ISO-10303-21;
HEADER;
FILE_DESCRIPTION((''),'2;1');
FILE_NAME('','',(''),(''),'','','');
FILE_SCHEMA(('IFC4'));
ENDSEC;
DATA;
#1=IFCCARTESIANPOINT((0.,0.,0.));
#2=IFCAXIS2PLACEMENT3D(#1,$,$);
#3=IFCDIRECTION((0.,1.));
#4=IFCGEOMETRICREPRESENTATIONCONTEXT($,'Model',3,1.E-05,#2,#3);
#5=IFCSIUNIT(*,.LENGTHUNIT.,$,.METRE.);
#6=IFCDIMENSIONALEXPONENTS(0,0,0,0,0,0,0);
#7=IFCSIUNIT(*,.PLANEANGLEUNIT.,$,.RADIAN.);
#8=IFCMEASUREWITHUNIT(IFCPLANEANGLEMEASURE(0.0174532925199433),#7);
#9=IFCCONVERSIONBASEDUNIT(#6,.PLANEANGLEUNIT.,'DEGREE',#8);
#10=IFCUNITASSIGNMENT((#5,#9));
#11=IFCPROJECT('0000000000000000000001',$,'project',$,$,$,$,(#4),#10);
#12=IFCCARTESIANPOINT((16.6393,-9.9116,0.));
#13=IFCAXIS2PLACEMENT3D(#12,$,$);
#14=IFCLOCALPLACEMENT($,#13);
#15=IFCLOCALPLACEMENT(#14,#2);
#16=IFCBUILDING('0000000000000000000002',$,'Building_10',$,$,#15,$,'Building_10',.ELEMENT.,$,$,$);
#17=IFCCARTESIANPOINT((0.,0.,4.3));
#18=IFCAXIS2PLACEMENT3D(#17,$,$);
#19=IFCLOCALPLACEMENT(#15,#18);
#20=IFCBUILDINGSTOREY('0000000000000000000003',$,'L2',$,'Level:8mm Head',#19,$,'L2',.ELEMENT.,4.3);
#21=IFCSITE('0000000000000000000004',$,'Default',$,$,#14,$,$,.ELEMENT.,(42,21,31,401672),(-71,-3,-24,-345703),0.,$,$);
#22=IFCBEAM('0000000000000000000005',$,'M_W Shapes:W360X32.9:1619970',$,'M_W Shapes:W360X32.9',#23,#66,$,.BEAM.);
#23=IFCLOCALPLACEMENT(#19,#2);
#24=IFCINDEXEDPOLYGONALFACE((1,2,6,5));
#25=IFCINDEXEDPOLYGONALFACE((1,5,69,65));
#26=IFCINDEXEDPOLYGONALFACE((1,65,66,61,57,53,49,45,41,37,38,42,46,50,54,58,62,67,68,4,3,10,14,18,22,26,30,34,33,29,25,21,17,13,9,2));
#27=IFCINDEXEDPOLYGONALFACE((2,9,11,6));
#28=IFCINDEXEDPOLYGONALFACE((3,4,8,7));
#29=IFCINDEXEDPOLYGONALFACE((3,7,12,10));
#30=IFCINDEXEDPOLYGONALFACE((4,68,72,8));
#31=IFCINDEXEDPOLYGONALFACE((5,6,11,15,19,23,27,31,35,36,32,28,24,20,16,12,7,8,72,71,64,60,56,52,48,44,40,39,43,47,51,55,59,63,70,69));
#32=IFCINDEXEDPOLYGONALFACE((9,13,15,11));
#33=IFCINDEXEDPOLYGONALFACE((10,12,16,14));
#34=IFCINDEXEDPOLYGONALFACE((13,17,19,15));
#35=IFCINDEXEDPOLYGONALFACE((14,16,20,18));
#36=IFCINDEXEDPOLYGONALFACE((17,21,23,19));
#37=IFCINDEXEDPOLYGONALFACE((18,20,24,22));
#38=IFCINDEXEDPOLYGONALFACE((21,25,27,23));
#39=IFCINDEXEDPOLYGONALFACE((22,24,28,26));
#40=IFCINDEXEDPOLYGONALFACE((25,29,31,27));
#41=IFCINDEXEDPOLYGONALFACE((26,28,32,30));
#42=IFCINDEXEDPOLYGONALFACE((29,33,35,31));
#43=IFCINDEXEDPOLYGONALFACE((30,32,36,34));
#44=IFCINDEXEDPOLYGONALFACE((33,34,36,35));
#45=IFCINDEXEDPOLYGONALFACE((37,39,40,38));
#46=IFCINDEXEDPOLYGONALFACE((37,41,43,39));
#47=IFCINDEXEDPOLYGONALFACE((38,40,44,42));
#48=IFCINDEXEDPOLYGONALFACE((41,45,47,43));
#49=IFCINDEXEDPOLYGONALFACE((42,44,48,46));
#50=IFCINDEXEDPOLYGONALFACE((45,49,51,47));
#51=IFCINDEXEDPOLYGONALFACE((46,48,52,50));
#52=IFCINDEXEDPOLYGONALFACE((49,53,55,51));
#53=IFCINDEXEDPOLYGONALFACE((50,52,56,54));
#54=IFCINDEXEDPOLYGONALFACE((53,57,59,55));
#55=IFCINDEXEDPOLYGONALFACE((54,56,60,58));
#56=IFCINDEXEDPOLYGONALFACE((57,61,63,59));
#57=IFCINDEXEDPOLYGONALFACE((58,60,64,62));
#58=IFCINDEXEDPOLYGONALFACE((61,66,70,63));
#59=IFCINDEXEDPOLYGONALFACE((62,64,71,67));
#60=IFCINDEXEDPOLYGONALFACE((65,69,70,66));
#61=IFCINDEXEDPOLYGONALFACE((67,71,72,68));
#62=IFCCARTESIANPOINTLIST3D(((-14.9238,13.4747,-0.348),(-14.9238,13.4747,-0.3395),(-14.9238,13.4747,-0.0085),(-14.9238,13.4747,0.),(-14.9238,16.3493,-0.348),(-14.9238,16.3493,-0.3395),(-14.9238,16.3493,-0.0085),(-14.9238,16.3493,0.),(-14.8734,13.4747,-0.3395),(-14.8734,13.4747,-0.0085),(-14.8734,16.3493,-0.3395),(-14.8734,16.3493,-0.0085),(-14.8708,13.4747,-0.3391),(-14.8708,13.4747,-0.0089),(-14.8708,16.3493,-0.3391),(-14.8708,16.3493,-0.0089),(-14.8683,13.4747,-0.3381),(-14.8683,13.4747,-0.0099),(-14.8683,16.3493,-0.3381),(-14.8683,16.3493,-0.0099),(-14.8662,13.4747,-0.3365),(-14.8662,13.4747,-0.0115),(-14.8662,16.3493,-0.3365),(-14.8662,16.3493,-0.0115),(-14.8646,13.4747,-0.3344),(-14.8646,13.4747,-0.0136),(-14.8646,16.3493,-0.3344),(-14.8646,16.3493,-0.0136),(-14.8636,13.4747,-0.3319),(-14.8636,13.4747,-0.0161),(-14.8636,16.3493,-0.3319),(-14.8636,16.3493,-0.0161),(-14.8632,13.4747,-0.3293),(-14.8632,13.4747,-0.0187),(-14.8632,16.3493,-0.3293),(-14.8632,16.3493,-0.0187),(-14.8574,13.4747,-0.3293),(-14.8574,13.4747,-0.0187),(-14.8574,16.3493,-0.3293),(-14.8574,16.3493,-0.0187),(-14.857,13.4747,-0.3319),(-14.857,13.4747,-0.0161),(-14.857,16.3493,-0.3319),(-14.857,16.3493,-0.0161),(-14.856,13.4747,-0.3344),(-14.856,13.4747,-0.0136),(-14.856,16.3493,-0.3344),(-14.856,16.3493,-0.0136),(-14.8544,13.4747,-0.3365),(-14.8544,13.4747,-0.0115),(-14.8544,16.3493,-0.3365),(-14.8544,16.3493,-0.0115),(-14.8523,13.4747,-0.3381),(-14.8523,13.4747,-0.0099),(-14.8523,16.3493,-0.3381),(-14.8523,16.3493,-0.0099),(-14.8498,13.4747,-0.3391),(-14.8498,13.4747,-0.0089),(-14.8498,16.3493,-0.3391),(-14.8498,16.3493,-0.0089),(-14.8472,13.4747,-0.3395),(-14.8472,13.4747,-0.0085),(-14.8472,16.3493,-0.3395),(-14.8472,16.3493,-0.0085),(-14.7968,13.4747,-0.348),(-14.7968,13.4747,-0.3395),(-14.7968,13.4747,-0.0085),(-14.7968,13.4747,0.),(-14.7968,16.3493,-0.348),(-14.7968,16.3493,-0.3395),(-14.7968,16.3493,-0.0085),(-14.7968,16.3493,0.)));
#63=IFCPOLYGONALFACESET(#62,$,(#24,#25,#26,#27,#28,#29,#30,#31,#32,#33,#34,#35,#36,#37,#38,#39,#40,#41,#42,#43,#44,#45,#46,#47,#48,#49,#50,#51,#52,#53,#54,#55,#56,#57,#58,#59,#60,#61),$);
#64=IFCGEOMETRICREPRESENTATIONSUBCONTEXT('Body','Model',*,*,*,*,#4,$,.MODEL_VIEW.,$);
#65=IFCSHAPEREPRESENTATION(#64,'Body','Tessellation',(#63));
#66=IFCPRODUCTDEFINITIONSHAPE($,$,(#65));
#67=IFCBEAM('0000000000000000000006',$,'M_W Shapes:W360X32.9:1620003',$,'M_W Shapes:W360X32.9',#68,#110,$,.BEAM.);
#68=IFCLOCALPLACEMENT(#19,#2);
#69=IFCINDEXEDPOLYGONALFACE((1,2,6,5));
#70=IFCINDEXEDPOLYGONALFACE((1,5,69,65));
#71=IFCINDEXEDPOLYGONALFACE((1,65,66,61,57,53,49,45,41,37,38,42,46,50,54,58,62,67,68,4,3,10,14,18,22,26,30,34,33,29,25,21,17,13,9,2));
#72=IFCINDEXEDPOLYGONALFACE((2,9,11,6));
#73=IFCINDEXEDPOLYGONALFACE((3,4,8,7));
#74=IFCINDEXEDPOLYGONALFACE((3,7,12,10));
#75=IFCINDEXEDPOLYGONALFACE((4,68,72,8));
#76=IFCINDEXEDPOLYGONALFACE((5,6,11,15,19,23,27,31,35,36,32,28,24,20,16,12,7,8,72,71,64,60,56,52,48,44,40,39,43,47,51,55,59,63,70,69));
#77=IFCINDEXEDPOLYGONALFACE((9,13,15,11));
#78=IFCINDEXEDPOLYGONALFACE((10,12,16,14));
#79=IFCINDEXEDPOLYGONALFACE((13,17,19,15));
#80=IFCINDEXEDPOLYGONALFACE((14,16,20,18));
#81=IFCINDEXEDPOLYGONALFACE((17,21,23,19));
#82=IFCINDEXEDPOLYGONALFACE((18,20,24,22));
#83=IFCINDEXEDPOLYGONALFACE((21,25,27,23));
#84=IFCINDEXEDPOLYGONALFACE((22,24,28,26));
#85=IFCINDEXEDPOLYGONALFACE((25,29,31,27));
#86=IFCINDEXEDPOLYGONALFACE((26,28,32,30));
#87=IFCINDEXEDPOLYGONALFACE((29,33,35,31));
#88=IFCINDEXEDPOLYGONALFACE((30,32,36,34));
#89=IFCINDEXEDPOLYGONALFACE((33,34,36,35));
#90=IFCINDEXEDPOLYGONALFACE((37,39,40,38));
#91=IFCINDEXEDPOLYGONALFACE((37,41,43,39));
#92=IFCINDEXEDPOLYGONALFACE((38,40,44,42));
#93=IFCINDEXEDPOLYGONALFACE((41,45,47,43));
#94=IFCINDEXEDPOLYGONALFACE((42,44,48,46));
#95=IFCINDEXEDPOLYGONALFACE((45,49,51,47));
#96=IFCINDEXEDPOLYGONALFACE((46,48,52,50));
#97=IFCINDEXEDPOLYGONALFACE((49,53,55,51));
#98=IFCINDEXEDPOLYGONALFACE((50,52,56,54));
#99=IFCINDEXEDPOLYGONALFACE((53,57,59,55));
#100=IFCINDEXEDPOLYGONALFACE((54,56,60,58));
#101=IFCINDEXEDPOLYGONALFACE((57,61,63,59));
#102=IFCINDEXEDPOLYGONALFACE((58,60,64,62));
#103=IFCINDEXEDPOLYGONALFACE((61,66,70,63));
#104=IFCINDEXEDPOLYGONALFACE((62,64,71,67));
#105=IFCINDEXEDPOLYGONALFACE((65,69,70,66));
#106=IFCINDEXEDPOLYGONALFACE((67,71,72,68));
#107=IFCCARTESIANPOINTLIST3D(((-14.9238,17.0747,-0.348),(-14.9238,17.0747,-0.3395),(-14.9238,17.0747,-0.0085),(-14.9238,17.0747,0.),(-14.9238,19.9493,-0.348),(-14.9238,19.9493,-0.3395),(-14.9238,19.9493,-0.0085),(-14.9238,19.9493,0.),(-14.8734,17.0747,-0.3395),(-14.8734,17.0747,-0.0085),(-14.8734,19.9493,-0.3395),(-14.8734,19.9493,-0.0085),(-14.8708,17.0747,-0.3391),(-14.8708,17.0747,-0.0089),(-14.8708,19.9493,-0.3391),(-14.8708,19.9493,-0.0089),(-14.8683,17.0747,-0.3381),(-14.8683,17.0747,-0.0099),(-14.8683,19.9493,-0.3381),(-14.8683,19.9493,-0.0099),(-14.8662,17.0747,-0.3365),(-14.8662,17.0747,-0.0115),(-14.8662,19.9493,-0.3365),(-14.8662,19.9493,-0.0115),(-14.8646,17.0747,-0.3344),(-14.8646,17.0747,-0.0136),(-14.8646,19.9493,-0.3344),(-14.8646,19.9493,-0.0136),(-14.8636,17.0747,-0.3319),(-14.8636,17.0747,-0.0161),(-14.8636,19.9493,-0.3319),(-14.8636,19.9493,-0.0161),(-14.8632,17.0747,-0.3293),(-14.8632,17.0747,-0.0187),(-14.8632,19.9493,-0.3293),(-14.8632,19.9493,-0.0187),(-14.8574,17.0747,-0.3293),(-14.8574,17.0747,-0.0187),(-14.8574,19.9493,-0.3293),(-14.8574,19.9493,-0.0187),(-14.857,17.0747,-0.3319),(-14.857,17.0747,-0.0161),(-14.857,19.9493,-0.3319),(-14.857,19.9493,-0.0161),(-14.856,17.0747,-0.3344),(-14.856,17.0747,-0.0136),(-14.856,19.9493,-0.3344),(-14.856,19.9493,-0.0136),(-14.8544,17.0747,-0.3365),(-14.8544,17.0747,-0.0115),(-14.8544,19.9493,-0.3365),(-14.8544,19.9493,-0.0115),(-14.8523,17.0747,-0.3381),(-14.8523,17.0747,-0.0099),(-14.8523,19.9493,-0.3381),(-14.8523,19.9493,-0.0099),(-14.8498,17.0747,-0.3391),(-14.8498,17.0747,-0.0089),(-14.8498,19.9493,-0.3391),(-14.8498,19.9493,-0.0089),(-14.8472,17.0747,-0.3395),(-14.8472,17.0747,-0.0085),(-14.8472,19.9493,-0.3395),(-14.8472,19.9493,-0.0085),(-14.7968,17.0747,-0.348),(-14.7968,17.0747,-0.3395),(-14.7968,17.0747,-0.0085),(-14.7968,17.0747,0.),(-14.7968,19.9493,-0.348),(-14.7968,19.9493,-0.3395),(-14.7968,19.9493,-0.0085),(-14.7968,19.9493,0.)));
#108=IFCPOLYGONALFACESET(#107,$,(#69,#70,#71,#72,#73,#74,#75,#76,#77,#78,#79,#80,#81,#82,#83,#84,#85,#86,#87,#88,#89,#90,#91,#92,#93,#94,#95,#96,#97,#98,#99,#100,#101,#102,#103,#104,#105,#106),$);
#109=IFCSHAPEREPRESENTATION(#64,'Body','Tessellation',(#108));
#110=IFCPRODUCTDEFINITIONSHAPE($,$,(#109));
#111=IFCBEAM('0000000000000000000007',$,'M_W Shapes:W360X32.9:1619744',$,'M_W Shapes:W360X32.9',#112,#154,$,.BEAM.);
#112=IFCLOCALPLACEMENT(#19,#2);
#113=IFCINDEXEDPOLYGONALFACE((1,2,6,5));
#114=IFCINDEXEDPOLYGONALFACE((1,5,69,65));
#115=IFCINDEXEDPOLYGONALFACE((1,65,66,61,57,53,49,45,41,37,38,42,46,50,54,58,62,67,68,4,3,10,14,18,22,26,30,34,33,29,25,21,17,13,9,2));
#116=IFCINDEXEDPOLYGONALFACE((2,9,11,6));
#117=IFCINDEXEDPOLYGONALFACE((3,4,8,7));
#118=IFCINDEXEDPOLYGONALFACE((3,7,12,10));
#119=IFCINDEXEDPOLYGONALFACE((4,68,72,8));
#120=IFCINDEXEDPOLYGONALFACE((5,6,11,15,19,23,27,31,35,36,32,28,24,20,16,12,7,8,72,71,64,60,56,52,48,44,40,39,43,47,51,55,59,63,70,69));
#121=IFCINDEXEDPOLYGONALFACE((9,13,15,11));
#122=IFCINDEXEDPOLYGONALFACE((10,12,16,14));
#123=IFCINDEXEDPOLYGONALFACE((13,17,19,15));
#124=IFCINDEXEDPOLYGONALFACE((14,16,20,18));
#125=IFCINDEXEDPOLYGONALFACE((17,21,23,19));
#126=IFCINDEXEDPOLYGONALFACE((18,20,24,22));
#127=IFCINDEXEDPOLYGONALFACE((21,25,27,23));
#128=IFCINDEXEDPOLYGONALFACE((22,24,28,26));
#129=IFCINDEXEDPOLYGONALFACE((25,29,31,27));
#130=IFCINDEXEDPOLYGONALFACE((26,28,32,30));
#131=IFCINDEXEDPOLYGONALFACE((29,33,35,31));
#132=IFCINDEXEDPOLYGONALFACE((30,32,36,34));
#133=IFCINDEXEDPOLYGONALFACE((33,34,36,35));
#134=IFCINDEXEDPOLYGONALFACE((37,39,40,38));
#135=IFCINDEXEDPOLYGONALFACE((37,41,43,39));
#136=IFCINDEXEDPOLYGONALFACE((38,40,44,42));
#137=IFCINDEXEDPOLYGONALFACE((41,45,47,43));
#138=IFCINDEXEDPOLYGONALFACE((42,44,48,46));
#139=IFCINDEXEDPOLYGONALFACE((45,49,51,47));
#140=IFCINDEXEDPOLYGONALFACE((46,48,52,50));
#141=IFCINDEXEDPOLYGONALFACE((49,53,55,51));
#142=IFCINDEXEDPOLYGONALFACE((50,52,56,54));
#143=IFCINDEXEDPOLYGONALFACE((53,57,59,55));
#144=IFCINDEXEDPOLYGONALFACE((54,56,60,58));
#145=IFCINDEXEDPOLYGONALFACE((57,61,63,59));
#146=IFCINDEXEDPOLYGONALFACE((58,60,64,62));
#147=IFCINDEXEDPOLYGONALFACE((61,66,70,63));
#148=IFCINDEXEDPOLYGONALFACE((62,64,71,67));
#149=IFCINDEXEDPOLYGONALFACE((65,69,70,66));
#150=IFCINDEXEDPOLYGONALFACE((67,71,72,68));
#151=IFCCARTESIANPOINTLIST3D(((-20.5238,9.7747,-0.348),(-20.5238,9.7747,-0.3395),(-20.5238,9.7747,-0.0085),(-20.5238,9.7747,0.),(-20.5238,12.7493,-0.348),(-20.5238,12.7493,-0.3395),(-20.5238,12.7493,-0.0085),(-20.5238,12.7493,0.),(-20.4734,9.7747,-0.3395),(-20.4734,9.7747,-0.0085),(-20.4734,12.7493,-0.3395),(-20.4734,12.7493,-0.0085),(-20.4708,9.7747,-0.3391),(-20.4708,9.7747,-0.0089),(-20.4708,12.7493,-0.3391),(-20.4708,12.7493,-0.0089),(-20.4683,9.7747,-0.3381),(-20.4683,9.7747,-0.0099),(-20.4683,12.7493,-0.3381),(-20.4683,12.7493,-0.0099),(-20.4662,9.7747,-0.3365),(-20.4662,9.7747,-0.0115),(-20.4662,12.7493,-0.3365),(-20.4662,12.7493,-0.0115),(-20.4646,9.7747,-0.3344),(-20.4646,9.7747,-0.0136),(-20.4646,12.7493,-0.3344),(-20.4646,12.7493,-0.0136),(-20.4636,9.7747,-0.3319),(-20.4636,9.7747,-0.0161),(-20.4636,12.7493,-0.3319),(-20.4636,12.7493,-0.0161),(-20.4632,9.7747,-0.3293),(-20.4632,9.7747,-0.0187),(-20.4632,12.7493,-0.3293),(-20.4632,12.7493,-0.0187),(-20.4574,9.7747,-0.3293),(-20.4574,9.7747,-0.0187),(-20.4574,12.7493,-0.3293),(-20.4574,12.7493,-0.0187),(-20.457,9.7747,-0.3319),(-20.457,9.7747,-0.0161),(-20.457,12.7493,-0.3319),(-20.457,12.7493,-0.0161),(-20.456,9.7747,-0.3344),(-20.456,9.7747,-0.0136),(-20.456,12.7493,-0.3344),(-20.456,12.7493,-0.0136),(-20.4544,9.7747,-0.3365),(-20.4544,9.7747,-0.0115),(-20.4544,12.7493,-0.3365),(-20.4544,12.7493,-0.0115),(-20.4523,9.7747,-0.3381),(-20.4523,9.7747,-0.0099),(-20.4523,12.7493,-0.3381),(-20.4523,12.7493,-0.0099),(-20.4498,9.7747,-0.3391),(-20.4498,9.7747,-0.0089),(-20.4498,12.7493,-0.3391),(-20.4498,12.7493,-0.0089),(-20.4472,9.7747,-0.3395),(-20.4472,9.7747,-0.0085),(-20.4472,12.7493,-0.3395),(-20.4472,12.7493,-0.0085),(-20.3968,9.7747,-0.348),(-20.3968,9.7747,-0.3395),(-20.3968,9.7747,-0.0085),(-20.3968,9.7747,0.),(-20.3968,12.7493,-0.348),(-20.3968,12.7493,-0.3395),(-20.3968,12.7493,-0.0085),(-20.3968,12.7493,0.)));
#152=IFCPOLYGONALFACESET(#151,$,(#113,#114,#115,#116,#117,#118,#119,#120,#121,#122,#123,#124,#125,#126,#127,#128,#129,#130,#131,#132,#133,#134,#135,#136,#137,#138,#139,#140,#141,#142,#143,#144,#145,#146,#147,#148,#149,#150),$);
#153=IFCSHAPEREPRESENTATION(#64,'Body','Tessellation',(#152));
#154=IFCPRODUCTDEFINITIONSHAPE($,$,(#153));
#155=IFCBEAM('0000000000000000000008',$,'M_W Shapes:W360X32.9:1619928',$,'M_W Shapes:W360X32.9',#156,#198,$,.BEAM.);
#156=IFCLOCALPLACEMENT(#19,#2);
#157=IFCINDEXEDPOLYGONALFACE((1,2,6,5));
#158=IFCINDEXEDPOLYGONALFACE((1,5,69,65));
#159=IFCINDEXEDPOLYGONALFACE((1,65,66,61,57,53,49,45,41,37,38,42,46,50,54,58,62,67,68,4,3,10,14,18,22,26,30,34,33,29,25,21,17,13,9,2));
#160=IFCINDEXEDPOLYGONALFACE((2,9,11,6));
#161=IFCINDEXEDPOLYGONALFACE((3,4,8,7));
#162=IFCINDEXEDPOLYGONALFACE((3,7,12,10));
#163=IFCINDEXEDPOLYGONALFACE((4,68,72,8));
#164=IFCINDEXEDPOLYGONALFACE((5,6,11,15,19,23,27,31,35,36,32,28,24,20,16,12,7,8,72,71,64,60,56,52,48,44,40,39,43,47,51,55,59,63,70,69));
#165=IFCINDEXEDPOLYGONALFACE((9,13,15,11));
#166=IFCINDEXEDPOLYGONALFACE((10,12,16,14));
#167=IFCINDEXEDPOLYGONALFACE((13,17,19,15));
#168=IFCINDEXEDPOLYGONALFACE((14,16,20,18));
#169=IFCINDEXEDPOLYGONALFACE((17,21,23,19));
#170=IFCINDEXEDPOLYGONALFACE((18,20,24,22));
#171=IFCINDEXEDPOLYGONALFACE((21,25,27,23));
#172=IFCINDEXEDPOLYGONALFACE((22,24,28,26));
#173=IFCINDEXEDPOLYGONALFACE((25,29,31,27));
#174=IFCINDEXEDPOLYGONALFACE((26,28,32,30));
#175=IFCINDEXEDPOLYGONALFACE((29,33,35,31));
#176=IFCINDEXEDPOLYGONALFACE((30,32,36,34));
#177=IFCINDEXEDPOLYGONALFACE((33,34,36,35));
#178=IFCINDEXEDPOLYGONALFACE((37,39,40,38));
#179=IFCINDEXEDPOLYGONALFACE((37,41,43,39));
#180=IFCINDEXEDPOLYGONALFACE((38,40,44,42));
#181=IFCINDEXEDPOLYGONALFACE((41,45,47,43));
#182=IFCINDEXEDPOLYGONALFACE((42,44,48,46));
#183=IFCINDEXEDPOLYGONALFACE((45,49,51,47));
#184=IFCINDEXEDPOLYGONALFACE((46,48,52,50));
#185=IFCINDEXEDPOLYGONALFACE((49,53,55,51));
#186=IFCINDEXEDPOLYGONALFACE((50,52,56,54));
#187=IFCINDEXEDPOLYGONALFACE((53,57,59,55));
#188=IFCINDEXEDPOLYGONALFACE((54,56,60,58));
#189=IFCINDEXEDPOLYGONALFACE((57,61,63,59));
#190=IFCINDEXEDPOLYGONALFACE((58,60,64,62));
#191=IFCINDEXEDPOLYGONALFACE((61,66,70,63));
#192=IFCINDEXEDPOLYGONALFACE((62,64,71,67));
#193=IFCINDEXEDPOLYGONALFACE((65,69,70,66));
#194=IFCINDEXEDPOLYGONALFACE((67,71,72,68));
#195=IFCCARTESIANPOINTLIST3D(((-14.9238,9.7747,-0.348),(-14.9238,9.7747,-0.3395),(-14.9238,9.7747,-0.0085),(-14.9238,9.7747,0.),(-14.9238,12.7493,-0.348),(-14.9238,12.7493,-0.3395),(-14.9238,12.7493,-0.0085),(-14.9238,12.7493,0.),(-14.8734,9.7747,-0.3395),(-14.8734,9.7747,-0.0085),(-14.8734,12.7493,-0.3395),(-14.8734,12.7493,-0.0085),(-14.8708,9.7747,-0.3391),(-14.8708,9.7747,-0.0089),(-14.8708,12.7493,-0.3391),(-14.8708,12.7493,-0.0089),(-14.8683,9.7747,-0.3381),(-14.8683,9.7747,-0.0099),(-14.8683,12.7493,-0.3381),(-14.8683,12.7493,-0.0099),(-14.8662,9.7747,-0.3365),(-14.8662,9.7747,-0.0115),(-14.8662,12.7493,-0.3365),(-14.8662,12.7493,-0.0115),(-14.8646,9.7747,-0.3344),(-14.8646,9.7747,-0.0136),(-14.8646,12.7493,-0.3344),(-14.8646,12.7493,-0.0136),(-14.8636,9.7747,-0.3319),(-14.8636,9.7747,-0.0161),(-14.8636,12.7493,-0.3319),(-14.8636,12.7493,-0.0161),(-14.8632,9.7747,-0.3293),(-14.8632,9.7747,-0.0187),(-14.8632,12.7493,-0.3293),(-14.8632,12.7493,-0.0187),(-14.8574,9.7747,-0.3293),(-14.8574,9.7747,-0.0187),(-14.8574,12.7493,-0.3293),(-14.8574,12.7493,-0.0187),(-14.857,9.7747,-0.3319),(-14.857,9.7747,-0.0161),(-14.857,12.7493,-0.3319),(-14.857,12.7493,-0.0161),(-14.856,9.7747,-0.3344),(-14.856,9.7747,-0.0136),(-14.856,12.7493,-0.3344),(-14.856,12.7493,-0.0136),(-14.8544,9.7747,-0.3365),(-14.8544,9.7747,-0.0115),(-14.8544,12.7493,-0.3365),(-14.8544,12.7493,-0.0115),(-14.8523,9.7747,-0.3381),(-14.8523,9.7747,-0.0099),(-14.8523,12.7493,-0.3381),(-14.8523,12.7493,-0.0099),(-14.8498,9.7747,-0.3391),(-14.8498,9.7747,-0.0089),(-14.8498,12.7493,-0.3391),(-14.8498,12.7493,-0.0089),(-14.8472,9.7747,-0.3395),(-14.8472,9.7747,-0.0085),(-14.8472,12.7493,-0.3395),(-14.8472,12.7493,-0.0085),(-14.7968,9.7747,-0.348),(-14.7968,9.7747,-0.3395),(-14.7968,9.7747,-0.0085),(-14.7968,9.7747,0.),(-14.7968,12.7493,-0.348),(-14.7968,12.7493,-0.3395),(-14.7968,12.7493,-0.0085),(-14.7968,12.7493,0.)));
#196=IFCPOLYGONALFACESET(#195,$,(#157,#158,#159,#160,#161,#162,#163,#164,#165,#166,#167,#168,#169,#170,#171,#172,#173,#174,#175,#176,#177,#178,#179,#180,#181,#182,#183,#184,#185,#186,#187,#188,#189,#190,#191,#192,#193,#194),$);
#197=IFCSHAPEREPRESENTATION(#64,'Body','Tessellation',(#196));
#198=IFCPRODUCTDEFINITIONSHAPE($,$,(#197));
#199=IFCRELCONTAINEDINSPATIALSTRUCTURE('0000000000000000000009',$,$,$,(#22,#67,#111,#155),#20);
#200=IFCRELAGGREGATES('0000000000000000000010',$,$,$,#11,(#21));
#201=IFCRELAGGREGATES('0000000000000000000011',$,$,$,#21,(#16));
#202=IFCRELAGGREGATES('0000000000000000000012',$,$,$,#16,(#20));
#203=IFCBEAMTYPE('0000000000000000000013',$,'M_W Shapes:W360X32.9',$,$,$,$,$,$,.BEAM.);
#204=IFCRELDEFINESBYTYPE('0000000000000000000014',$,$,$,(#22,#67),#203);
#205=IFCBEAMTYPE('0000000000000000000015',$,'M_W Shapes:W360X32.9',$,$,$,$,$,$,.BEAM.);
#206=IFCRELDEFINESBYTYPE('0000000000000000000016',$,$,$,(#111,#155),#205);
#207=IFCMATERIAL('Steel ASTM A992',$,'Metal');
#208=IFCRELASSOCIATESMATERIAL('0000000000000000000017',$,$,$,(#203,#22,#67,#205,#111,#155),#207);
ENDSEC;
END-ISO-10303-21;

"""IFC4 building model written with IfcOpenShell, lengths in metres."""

from ifc_helpers import new_model, entity, si_unit, converted_unit, direction, frame, origin, place, context, subcontext, project, spatial, line, arc, indexed_curve, outline, extrude, source, transform, mapped, material, type_object, type_shapes, element, save


model = new_model("IFC4")

# Units and contexts
model_context = context("Model", 3, precision=1e-05, world=origin(), true_north=direction((0.0, 1.0)))
body_context = subcontext(model_context, "Body", "Model", "MODEL_VIEW")
ifc_project = project(units=[si_unit("LENGTHUNIT", "METRE"), converted_unit("PLANEANGLEUNIT", "DEGREE", entity("IfcPlaneAngleMeasure", 0.0174532925199433), si_unit("PLANEANGLEUNIT", "RADIAN"), dimensions=[0, 0, 0, 0, 0, 0, 0])], contexts=[model_context])

# Site, building, storey
site_placement = place(None, frame((16.6393, -9.9116, 0.0)))
site = spatial("IfcSite", under=ifc_project, at=site_placement, Name="Default", CompositionType="ELEMENT", RefLatitude=(42, 21, 31, 401672), RefLongitude=(-71, -3, -24, -345703), RefElevation=0.0)
building_placement = place(site_placement, origin())
building = spatial("IfcBuilding", under=site, at=building_placement, Name="Building_10", LongName="Building_10", CompositionType="ELEMENT")
storey_placement = place(building_placement, frame((0.0, 0.0, 4.3)))
storey = spatial("IfcBuildingStorey", under=building, at=storey_placement, Name="L2", ObjectType="Level:8mm Head", LongName="L2", CompositionType="ELEMENT", Elevation=4.3)

# Shared definitions
ifc_material_1 = material(Name="Steel ASTM A992", Category="Metal")

# Beams
beam_type_1 = type_object("IfcBeamType", Name="M_W Shapes:W360X32.9", PredefinedType="BEAM", material=ifc_material_1)
shared_shape_1 = source(origin(), body_context, "Body", "SweptSolid", [
    extrude(outline(indexed_curve([(-0.0635, -0.1655), (-0.0635, -0.174), (0.0635, -0.174), (0.0635, -0.1655), (0.0131, -0.1655), (0.0059, -0.1625), (0.0029, -0.1553), (0.0029, 0.1553), (0.0059, 0.1625), (0.0131, 0.1655), (0.0635, 0.1655), (0.0635, 0.174), (-0.0635, 0.174), (-0.0635, 0.1655), (-0.0131, 0.1655), (-0.0059, 0.1625), (-0.0029, 0.1553), (-0.0029, -0.1553), (-0.0059, -0.1625), (-0.0131, -0.1655)], segments=[line(1, 2, 3, 4, 5), arc(5, 6, 7), line(7, 8), arc(8, 9, 10), line(10, 11, 12, 13, 14, 15), arc(15, 16, 17), line(17, 18), arc(18, 19, 20), line(20, 1)], self_intersect=False)), frame((-1.4373, 0.0, 0.0), z_axis=(-1.0, 0.0, 0.0), x_axis=(0.0, -1.0, 0.0)), (0.0, 0.0, -1.0), 2.8746),
])
type_shapes(beam_type_1, [shared_shape_1])
for number, where, z_axis, x_axis, name in (
    (1, (-14.8603, 14.912, -0.174), (0.0, 0.0, 1.0), (0.0, -1.0, 0.0), "M_W Shapes:W360X32.9:1619970"),
    (2, (-14.8603, 18.512, -0.174), (0.0, 0.0, 1.0), (0.0, -1.0, 0.0), "M_W Shapes:W360X32.9:1620003"),
):
    element("IfcBeam", number, at=place(storey_placement, frame(where, z_axis=z_axis, x_axis=x_axis)), inside=storey, type_object=beam_type_1, material=ifc_material_1, Name=name, ObjectType="M_W Shapes:W360X32.9", PredefinedType="BEAM", context=body_context, shape_type="MappedRepresentation", body=[
        mapped(shared_shape_1, transform((0.0, 0.0, 0.0), scale=1.0)),
    ])
beam_type_2 = type_object("IfcBeamType", Name="M_W Shapes:W360X32.9", PredefinedType="BEAM", material=ifc_material_1)
shared_shape_2 = source(origin(), body_context, "Body", "SweptSolid", [
    extrude(outline(indexed_curve([(-0.0635, -0.1655), (-0.0635, -0.174), (0.0635, -0.174), (0.0635, -0.1655), (0.0131, -0.1655), (0.0059, -0.1625), (0.0029, -0.1553), (0.0029, 0.1553), (0.0059, 0.1625), (0.0131, 0.1655), (0.0635, 0.1655), (0.0635, 0.174), (-0.0635, 0.174), (-0.0635, 0.1655), (-0.0131, 0.1655), (-0.0059, 0.1625), (-0.0029, 0.1553), (-0.0029, -0.1553), (-0.0059, -0.1625), (-0.0131, -0.1655)], segments=[line(1, 2, 3, 4, 5), arc(5, 6, 7), line(7, 8), arc(8, 9, 10), line(10, 11, 12, 13, 14, 15), arc(15, 16, 17), line(17, 18), arc(18, 19, 20), line(20, 1)], self_intersect=False)), frame((-1.4873, 0.0, 0.0), z_axis=(-1.0, 0.0, 0.0), x_axis=(0.0, -1.0, 0.0)), (0.0, 0.0, -1.0), 2.9746),
])
type_shapes(beam_type_2, [shared_shape_2])
for number, where, z_axis, x_axis, name in (
    (3, (-20.4603, 11.262, -0.174), (0.0, 0.0, 1.0), (0.0, 1.0, 0.0), "M_W Shapes:W360X32.9:1619744"),
    (4, (-14.8603, 11.262, -0.174), (0.0, 0.0, 1.0), (0.0, -1.0, 0.0), "M_W Shapes:W360X32.9:1619928"),
):
    element("IfcBeam", number, at=place(storey_placement, frame(where, z_axis=z_axis, x_axis=x_axis)), inside=storey, type_object=beam_type_2, material=ifc_material_1, Name=name, ObjectType="M_W Shapes:W360X32.9", PredefinedType="BEAM", context=body_context, shape_type="MappedRepresentation", body=[
        mapped(shared_shape_2, transform((0.0, 0.0, 0.0), scale=1.0)),
    ])

save(model, "model.ifc")
